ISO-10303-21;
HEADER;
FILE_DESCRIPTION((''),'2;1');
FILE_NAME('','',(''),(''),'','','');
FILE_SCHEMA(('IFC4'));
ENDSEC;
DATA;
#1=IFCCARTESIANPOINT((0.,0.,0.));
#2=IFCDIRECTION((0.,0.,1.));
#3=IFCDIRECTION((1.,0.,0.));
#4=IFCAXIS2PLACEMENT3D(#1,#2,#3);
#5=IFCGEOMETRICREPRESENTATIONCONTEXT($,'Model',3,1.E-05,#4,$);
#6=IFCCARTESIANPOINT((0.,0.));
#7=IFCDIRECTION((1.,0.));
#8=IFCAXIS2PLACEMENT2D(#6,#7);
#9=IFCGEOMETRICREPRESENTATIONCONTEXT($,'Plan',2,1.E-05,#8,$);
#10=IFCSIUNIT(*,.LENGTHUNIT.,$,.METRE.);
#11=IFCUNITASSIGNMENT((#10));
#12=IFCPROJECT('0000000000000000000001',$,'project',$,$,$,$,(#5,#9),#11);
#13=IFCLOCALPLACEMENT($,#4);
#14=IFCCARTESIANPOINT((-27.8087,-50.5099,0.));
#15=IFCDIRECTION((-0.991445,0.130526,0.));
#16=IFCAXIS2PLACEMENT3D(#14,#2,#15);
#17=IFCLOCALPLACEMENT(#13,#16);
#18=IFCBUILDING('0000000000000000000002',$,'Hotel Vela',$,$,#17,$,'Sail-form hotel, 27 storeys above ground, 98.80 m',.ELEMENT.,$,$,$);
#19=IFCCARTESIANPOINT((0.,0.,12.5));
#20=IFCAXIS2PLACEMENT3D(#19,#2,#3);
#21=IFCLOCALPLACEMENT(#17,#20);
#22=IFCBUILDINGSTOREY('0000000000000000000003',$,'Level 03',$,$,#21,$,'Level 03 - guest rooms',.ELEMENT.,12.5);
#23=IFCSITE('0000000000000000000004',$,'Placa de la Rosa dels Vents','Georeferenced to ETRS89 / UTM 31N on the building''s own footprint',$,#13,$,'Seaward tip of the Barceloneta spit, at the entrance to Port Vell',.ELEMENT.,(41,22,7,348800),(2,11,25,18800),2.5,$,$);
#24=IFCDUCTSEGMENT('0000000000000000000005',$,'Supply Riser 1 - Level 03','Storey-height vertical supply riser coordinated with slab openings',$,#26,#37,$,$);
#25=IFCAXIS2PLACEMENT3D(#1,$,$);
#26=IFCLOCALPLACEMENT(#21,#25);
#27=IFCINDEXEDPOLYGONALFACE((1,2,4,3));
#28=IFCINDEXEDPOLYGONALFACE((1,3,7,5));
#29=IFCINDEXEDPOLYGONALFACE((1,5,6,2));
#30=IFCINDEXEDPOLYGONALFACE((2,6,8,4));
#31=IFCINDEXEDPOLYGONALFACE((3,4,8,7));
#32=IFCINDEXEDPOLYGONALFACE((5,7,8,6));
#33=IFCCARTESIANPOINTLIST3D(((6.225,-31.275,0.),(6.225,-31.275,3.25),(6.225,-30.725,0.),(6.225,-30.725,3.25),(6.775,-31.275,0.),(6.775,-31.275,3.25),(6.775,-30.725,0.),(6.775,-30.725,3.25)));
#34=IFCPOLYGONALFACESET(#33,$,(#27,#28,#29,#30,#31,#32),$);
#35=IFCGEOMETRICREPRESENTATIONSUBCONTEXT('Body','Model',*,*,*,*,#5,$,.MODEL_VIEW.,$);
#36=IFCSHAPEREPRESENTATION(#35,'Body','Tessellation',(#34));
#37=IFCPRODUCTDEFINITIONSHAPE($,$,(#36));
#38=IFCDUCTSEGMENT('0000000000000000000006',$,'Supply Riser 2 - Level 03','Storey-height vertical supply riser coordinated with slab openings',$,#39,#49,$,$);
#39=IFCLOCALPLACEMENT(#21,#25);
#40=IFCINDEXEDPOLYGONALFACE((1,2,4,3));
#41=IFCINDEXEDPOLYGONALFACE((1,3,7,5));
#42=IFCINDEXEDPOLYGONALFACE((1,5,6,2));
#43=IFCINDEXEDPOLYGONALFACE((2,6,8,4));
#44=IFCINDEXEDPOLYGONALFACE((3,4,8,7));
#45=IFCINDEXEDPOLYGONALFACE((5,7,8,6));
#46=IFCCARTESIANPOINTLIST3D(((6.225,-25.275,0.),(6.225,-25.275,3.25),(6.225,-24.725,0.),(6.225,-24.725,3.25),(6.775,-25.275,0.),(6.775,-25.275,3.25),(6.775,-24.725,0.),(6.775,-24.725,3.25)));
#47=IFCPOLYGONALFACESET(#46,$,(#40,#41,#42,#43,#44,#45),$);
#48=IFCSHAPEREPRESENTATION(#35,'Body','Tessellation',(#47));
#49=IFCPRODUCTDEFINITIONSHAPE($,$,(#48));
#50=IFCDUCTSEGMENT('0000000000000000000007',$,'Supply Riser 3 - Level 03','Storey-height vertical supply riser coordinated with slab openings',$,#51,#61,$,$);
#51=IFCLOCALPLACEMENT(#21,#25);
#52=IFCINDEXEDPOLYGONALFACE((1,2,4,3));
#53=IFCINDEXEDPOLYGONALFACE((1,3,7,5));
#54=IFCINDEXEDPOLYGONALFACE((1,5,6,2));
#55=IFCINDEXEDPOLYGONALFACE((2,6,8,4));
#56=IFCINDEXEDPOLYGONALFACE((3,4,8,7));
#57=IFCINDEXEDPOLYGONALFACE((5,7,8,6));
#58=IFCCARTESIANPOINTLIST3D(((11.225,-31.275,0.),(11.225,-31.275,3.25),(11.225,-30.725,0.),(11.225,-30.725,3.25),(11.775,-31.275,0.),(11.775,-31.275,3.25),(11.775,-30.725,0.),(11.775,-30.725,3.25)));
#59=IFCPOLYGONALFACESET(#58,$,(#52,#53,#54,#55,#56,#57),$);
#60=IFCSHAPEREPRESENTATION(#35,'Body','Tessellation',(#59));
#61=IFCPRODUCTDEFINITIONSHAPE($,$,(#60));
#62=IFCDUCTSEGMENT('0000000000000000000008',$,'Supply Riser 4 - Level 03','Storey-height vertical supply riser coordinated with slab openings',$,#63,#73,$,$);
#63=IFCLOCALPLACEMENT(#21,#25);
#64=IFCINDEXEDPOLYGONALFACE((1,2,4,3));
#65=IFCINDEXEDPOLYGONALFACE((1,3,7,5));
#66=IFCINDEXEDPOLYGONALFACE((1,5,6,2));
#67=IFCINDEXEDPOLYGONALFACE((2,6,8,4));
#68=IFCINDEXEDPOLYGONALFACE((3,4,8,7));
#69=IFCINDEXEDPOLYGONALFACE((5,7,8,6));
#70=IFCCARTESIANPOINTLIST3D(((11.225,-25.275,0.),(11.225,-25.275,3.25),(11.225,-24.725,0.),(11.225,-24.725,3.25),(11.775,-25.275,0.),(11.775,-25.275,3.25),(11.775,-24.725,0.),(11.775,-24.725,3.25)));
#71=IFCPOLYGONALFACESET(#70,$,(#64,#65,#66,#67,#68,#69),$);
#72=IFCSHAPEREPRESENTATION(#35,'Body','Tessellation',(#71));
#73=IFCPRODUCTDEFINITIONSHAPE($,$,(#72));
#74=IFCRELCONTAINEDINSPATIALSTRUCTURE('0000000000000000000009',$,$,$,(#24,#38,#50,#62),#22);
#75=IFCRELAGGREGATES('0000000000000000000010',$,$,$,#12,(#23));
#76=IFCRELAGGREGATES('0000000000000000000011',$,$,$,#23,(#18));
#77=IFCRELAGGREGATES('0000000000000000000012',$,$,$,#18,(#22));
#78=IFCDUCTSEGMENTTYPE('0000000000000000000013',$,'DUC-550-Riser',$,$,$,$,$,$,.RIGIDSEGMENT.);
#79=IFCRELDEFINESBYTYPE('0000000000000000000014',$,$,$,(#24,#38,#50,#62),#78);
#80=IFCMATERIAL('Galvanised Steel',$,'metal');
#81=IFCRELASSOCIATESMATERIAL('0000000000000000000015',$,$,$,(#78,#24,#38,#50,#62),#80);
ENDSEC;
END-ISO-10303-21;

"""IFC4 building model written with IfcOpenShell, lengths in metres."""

from ifc_helpers import new_model, si_unit, frame, origin_with_axes, origin_2d_with_axis, place, context, subcontext, project, spatial, line, indexed_curve, outline, extrude, material, type_object, element, save


model = new_model("IFC4")

# Units and contexts
model_context = context("Model", 3, precision=1e-05, world=origin_with_axes())
plan_context = context("Plan", 2, precision=1e-05, world=origin_2d_with_axis())
body_context = subcontext(model_context, "Body", "Model", "MODEL_VIEW")
ifc_project = project(units=[si_unit("LENGTHUNIT", "METRE")], contexts=[model_context, plan_context])

# Site, building, storey
site_placement = place(None, origin_with_axes())
site = spatial("IfcSite", under=ifc_project, at=site_placement, Name="Placa de la Rosa dels Vents", Description="Georeferenced to ETRS89 / UTM 31N on the building's own footprint", LongName="Seaward tip of the Barceloneta spit, at the entrance to Port Vell", CompositionType="ELEMENT", RefLatitude=(41, 22, 7, 348800), RefLongitude=(2, 11, 25, 18800), RefElevation=2.5)
building_placement = place(site_placement, frame((-27.8087, -50.5099, 0.0), z_axis=(0.0, 0.0, 1.0), x_axis=(-0.991445, 0.130526, 0.0)))
building = spatial("IfcBuilding", under=site, at=building_placement, Name="Hotel Vela", LongName="Sail-form hotel, 27 storeys above ground, 98.80 m", CompositionType="ELEMENT")
storey_placement = place(building_placement, frame((0.0, 0.0, 12.5), z_axis=(0.0, 0.0, 1.0), x_axis=(1.0, 0.0, 0.0)))
storey = spatial("IfcBuildingStorey", under=building, at=storey_placement, Name="Level 03", LongName="Level 03 - guest rooms", CompositionType="ELEMENT", Elevation=12.5)

# Duct segments
ifc_material = material(Name="Galvanised Steel", Category="metal")
duct_segment_type = type_object("IfcDuctSegmentType", Name="DUC-550-Riser", PredefinedType="RIGIDSEGMENT", material=ifc_material)
for number, where, z_axis, x_axis, name in (
    (1, (6.225, -31.275, 0.0), (0.0, 0.0, 1.0), (1.0, 0.0, 0.0), "Supply Riser 1 - Level 03"),
    (2, (6.225, -25.275, 0.0), (0.0, 0.0, 1.0), (1.0, 0.0, 0.0), "Supply Riser 2 - Level 03"),
    (3, (11.225, -31.275, 0.0), (0.0, 0.0, 1.0), (1.0, 0.0, 0.0), "Supply Riser 3 - Level 03"),
    (4, (11.225, -25.275, 0.0), (0.0, 0.0, 1.0), (1.0, 0.0, 0.0), "Supply Riser 4 - Level 03"),
):
    element("IfcDuctSegment", number, at=place(storey_placement, frame(where, z_axis=z_axis, x_axis=x_axis)), inside=storey, type_object=duct_segment_type, material=ifc_material, Name=name, Description="Storey-height vertical supply riser coordinated with slab openings", context=body_context, shape_type="SweptSolid", body=[
        extrude(outline(indexed_curve([(0.0, 0.0), (0.55, 0.0), (0.55, 0.55), (0.0, 0.55)], segments=[line(1, 2, 3, 4, 1)])), origin_with_axes(), (0.0, 0.0, 1.0), 3.25),
    ])

save(model, "model.ifc")
